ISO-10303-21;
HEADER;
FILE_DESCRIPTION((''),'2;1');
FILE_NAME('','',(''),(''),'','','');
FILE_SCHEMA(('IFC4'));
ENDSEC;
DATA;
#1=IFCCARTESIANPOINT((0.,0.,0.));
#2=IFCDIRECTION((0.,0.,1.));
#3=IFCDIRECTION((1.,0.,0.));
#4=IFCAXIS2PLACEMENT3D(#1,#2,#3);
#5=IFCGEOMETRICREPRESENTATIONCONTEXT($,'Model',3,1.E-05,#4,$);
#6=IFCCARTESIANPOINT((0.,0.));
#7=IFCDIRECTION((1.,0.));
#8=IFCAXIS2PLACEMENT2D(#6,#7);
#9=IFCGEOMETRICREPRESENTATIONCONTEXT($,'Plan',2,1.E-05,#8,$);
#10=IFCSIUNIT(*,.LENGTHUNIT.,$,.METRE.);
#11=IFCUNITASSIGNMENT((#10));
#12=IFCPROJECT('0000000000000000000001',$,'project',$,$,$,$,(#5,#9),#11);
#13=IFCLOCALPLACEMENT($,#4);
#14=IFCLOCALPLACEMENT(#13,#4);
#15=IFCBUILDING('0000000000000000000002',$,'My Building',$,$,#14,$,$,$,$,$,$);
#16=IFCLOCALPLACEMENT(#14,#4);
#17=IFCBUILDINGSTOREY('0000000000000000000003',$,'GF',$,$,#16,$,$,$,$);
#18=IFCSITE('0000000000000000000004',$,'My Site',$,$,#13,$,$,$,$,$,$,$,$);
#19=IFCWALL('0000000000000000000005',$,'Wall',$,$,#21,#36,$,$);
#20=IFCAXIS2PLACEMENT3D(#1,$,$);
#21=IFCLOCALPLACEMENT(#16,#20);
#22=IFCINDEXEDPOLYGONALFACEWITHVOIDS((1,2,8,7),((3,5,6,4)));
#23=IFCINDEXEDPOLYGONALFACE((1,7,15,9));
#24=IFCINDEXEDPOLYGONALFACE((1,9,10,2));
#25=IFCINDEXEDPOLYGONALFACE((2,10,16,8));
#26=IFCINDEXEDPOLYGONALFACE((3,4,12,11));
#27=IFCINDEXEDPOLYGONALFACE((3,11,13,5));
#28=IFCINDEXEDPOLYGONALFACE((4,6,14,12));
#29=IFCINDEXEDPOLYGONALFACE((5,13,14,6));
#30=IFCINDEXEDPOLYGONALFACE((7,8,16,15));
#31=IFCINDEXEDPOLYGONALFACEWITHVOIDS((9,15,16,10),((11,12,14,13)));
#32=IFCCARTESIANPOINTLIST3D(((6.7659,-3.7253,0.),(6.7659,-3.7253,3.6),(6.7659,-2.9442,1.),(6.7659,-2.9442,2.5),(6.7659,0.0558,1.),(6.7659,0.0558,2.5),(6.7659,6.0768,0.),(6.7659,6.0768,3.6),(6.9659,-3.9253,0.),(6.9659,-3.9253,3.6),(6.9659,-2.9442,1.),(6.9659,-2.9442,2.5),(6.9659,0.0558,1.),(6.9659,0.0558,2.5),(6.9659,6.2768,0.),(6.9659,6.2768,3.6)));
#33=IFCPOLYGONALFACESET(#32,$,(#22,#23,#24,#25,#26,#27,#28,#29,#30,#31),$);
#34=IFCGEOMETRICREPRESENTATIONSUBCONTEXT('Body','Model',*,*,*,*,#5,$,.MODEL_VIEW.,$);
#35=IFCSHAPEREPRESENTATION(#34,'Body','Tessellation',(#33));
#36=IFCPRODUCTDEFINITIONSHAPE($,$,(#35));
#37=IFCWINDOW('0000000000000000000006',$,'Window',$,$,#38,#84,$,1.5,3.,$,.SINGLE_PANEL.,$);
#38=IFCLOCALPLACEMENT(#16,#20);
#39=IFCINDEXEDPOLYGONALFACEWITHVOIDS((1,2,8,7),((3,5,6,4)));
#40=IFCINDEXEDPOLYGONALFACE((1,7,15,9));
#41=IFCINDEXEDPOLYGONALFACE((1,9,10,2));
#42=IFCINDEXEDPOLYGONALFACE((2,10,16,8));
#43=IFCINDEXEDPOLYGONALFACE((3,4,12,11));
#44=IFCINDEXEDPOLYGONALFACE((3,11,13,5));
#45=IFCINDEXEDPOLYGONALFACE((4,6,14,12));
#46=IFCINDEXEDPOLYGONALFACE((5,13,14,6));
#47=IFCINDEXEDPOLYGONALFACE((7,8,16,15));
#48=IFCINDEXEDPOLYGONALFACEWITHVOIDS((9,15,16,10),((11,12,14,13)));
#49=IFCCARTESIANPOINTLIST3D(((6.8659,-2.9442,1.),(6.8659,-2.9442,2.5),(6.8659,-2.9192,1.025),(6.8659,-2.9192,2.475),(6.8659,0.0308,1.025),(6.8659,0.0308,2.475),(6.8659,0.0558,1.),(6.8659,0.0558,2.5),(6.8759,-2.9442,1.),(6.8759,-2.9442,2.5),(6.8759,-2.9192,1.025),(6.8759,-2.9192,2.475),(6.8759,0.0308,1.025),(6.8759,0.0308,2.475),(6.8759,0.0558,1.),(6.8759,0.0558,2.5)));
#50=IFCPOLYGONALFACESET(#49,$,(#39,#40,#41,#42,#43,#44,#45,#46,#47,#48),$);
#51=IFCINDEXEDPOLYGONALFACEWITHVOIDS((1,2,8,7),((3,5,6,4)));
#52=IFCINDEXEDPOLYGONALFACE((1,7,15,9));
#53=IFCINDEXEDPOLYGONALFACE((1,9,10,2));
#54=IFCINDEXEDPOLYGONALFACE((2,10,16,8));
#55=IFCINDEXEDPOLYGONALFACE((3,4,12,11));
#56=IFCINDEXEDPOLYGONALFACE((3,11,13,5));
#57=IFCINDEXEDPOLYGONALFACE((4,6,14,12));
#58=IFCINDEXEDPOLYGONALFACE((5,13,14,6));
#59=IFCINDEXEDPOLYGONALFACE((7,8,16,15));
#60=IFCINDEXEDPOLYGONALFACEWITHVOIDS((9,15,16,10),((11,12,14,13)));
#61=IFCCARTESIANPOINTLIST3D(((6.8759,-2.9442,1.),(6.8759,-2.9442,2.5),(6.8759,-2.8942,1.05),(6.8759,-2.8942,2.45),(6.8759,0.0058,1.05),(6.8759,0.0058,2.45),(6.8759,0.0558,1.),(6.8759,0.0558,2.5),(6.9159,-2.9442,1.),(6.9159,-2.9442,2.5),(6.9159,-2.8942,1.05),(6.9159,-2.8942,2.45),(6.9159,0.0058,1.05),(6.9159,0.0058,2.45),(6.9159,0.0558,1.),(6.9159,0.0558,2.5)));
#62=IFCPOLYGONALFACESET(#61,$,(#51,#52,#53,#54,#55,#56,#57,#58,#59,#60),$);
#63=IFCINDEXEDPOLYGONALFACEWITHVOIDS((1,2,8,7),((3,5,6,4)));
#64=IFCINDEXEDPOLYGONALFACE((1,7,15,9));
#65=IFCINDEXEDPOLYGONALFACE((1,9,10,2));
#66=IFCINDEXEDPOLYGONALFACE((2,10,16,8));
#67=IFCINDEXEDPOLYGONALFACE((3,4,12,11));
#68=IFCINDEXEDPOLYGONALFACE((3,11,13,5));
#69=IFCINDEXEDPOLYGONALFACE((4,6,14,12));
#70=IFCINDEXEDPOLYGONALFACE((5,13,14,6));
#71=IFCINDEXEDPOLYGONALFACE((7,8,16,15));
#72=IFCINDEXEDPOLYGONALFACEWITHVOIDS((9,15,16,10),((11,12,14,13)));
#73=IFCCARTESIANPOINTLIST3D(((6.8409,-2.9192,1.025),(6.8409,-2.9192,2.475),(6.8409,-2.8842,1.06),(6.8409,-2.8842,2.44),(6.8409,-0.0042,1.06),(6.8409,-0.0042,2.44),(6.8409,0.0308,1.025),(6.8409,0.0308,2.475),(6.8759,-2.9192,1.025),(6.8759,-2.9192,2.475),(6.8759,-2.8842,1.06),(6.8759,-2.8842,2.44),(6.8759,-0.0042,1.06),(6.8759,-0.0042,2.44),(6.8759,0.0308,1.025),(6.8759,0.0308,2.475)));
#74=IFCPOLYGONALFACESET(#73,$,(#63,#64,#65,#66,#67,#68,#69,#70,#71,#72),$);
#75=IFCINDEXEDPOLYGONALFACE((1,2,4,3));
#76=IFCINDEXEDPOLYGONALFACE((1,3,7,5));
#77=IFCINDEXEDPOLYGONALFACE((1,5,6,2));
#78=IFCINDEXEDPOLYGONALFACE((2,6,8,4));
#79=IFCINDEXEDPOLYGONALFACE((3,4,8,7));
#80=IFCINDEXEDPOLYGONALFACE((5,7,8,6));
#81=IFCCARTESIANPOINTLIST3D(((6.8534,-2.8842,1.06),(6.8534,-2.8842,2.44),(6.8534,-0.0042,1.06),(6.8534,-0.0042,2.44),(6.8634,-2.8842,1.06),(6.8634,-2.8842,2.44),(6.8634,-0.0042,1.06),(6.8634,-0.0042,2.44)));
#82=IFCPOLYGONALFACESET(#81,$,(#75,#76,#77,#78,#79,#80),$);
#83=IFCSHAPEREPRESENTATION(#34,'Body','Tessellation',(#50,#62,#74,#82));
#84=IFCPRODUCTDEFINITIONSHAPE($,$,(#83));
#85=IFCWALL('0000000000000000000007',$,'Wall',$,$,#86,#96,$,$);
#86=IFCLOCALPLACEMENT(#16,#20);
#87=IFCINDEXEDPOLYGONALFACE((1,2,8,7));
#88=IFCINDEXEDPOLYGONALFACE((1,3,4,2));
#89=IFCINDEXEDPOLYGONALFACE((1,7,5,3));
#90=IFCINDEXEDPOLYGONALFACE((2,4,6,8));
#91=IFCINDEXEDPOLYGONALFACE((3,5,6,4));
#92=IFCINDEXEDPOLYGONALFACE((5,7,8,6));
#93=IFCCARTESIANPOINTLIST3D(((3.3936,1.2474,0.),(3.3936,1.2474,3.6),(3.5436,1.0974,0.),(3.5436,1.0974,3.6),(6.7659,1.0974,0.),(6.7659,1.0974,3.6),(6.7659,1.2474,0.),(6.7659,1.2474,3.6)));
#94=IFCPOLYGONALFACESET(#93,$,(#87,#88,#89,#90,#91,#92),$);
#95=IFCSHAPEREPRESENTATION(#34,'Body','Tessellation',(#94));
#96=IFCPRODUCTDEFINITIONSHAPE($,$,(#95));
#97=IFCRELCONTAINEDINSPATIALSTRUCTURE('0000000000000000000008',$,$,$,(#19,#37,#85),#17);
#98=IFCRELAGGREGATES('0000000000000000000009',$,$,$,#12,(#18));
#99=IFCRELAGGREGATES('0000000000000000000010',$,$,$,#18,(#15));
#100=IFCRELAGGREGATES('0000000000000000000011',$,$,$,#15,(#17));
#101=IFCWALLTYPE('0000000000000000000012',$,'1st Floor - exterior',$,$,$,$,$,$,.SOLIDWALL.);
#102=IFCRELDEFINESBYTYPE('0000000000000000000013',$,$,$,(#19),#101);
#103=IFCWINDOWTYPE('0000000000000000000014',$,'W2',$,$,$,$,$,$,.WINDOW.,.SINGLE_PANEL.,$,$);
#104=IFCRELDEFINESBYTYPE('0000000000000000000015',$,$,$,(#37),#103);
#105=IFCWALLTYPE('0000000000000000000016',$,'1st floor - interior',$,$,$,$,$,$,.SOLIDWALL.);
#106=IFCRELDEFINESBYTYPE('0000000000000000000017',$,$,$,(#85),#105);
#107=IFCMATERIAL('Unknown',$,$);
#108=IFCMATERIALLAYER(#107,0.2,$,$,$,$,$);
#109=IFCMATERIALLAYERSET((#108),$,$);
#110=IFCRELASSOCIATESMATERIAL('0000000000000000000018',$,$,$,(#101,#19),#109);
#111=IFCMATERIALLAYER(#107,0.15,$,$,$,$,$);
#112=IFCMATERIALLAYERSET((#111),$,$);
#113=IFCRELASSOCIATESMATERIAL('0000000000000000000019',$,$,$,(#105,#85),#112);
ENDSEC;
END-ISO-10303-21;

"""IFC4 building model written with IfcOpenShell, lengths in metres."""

from ifc_helpers import new_model, entity, si_unit, frame, origin_with_axes, origin_2d_with_axis, place, context, subcontext, project, spatial, line, indexed_curve, outline, extrude, shape, source, transform, mapped, material, layer, layer_set, layer_usage, type_object, type_shapes, element, fill, save


model = new_model("IFC4")

# Units and contexts
model_context = context("Model", 3, precision=1e-05, world=origin_with_axes())
plan_context = context("Plan", 2, precision=1e-05, world=origin_2d_with_axis())
body_context_1 = subcontext(model_context, "Body", "Model", "MODEL_VIEW")
body_context_2 = subcontext(plan_context, "Body", "Plan", "PLAN_VIEW")
ifc_project = project(units=[si_unit("LENGTHUNIT", "METRE")], contexts=[model_context, plan_context])

# Site, building, storey
site_placement = place(None, origin_with_axes())
site = spatial("IfcSite", under=ifc_project, at=site_placement, Name="My Site")
building_placement = place(site_placement, origin_with_axes())
building = spatial("IfcBuilding", under=site, at=building_placement, Name="My Building")
storey_placement = place(building_placement, origin_with_axes())
storey = spatial("IfcBuildingStorey", under=building, at=storey_placement, Name="GF")

# Shared definitions
ifc_material = material(Name="Unknown")

# Wall, opening, window
ifc_layer_1 = layer(ifc_material, 0.2)
ifc_layer_set_1 = layer_set([ifc_layer_1])
ifc_layer_usage_1 = layer_usage(ifc_layer_set_1, "AXIS2", "POSITIVE", 0.0)
wall_type_1 = type_object("IfcWallType", Name="1st Floor - exterior", PredefinedType="SOLIDWALL", material=ifc_layer_set_1)
wall_1_placement = place(storey_placement, frame((6.7659, 6.0768, 0.0), z_axis=(0.0, 0.0, 1.0), x_axis=(0.0, -1.0, 0.0)))
wall_1 = element("IfcWall", 1, at=wall_1_placement, inside=storey, type_object=wall_type_1, material=ifc_layer_usage_1, Name="Wall", context=body_context_1, shape_type="SweptSolid", body=[
    extrude(outline(indexed_curve([(0.0, 0.0), (-0.2, 0.2), (10.0021, 0.2), (9.8021, 0.0)], segments=[line(1, 2, 3, 4, 1)])), origin_with_axes(), (0.0, 0.0, 1.0), 3.6),
])
shared_shape_1 = source(origin_with_axes(), body_context_1, "Body", "SweptSolid", [
    extrude(outline(indexed_curve([(0.0, 0.0), (3.0, 0.0), (3.0, 1.5), (0.0, 1.5)], segments=[line(1, 2, 3, 4, 1)])), frame((0.0, -0.6, 0.0), z_axis=(0.0, -1.0, 0.0), x_axis=(1.0, 0.0, 0.0)), (0.0, 0.0, -1.0), 1.2),
])
opening_1_placement = place(wall_1_placement, frame((9.021, 0.2, 1.0), z_axis=(0.0, 0.0, 1.0), x_axis=(-1.0, 0.0, 0.0)))
opening_1 = element("IfcOpeningElement", 2, at=opening_1_placement, cuts=wall_1, PredefinedType="OPENING", context=body_context_1, shape_type="MappedRepresentation", body=[
    mapped(shared_shape_1, transform((0.0, 0.0, 0.0), x_axis=(1.0, 0.0, 0.0), y_axis=(0.0, 1.0, 0.0), z_axis=(0.0, 0.0, 1.0), scale=1.0)),
])
window_type_1 = type_object("IfcWindowType", Name="W2", PartitioningType="SINGLE_PANEL", PredefinedType="WINDOW")
shared_shape_2 = source(origin_with_axes(), body_context_1, "Body", "SweptSolid", [
    extrude(outline(indexed_curve([(0.0, 0.0), (3.0, 0.0), (3.0, 1.5), (0.0, 1.5)], segments=[line(1, 2, 3, 4, 1)]), holes=[indexed_curve([(0.025, 0.025), (2.975, 0.025), (2.975, 1.475), (0.025, 1.475)], segments=[line(1, 2, 3, 4, 1)])]), frame((0.0, 0.09, 0.0), z_axis=(0.0, -1.0, 0.0), x_axis=(1.0, 0.0, 0.0)), (0.0, 0.0, -1.0), 0.01),
    extrude(outline(indexed_curve([(0.0, 0.0), (3.0, 0.0), (3.0, 1.5), (0.0, 1.5)], segments=[line(1, 2, 3, 4, 1)]), holes=[indexed_curve([(0.05, 0.05), (2.95, 0.05), (2.95, 1.45), (0.05, 1.45)], segments=[line(1, 2, 3, 4, 1)])]), frame((0.0, 0.05, 0.0), z_axis=(0.0, -1.0, 0.0), x_axis=(1.0, 0.0, 0.0)), (0.0, 0.0, -1.0), 0.04),
    extrude(outline(indexed_curve([(0.0, 0.0), (2.95, 0.0), (2.95, 1.45), (0.0, 1.45)], segments=[line(1, 2, 3, 4, 1)]), holes=[indexed_curve([(0.035, 0.035), (2.915, 0.035), (2.915, 1.415), (0.035, 1.415)], segments=[line(1, 2, 3, 4, 1)])]), frame((0.025, 0.09, 0.025), z_axis=(0.0, -1.0, 0.0), x_axis=(1.0, 0.0, 0.0)), (0.0, 0.0, -1.0), 0.035),
    extrude(outline(indexed_curve([(0.035, 0.035), (2.915, 0.035), (2.915, 1.415), (0.035, 1.415)], segments=[line(1, 2, 3, 4, 1)])), frame((0.025, 0.1025, 0.025), z_axis=(0.0, -1.0, 0.0), x_axis=(1.0, 0.0, 0.0)), (0.0, 0.0, -1.0), 0.01),
])
shared_shape_3 = source(origin_with_axes(), body_context_2, "Body", "Curve2D", [
    entity("IfcIndexedPolyCurve", entity("IfcCartesianPointList2D", [[0.05, 0.05], [2.95, 0.05]])),
    entity("IfcIndexedPolyCurve", entity("IfcCartesianPointList2D", [[0.0, 0.1], [0.025, 0.1], [0.025, 0.09], [0.05, 0.09], [0.05, 0.05], [0.0, 0.05]]), [entity("IfcLineIndex", [1, 2, 3, 4, 5, 6, 1])]),
    entity("IfcIndexedPolyCurve", entity("IfcCartesianPointList2D", [[3.0, 0.1], [2.975, 0.1], [2.975, 0.09], [2.95, 0.09], [2.95, 0.05], [3.0, 0.05]]), [entity("IfcLineIndex", [1, 2, 3, 4, 5, 6, 1])]),
    entity("IfcIndexedPolyCurve", entity("IfcCartesianPointList2D", [[0.025, 0.09], [0.06, 0.09], [0.06, 0.125], [0.025, 0.125]]), [entity("IfcLineIndex", [1, 2, 3, 4, 1])]),
    entity("IfcIndexedPolyCurve", entity("IfcCartesianPointList2D", [[2.975, 0.09], [2.94, 0.09], [2.94, 0.125], [2.975, 0.125]]), [entity("IfcLineIndex", [1, 2, 3, 4, 1])]),
    entity("IfcIndexedPolyCurve", entity("IfcCartesianPointList2D", [[0.06, 0.09], [2.94, 0.09]])),
    entity("IfcIndexedPolyCurve", entity("IfcCartesianPointList2D", [[0.06, 0.125], [2.94, 0.125]])),
    entity("IfcIndexedPolyCurve", entity("IfcCartesianPointList2D", [[0.06, 0.1075], [2.94, 0.1075]])),
])
type_shapes(window_type_1, [shared_shape_2, shared_shape_3])
window_1_placement = place(opening_1_placement, frame((0.0, 0.0, 0.0), z_axis=(0.0, 0.0, 1.0), x_axis=(1.0, 0.0, 0.0)))
window_1 = element("IfcWindow", 3, at=window_1_placement, inside=storey, type_object=window_type_1, Name="Window", OverallHeight=1.5, OverallWidth=3.0, PartitioningType="SINGLE_PANEL", shapes=[
    shape(body_context_1, "Body", "MappedRepresentation", [mapped(shared_shape_2, transform((0.0, 0.0, 0.0), x_axis=(1.0, 0.0, 0.0), y_axis=(0.0, 1.0, 0.0), z_axis=(0.0, 0.0, 1.0), scale=1.0))]),
    shape(body_context_2, "Body", "MappedRepresentation", [mapped(shared_shape_3, transform((0.0, 0.0, 0.0), x_axis=(1.0, 0.0, 0.0), y_axis=(0.0, 1.0, 0.0), z_axis=(0.0, 0.0, 1.0), scale=1.0))]),
])
fill(opening_1, window_1)

# Wall
ifc_layer_2 = layer(ifc_material, 0.15)
ifc_layer_set_2 = layer_set([ifc_layer_2])
ifc_layer_usage_2 = layer_usage(ifc_layer_set_2, "AXIS2", "POSITIVE", 0.0)
wall_type_2 = type_object("IfcWallType", Name="1st floor - interior", PredefinedType="SOLIDWALL", material=ifc_layer_set_2)
wall_2_placement = place(storey_placement, frame((6.7659, 1.2474, 0.0), z_axis=(0.0, 0.0, 1.0), x_axis=(-1.0, 0.0, 0.0)))
element("IfcWall", 4, at=wall_2_placement, inside=storey, type_object=wall_type_2, material=ifc_layer_usage_2, Name="Wall", context=body_context_1, shape_type="SweptSolid", body=[
    extrude(outline(indexed_curve([(0.0, 0.0), (0.0, 0.15), (3.2223, 0.15), (3.3723, 0.0)], segments=[line(1, 2, 3, 4, 1)])), origin_with_axes(), (0.0, 0.0, 1.0), 3.6),
])

save(model, "model.ifc")
